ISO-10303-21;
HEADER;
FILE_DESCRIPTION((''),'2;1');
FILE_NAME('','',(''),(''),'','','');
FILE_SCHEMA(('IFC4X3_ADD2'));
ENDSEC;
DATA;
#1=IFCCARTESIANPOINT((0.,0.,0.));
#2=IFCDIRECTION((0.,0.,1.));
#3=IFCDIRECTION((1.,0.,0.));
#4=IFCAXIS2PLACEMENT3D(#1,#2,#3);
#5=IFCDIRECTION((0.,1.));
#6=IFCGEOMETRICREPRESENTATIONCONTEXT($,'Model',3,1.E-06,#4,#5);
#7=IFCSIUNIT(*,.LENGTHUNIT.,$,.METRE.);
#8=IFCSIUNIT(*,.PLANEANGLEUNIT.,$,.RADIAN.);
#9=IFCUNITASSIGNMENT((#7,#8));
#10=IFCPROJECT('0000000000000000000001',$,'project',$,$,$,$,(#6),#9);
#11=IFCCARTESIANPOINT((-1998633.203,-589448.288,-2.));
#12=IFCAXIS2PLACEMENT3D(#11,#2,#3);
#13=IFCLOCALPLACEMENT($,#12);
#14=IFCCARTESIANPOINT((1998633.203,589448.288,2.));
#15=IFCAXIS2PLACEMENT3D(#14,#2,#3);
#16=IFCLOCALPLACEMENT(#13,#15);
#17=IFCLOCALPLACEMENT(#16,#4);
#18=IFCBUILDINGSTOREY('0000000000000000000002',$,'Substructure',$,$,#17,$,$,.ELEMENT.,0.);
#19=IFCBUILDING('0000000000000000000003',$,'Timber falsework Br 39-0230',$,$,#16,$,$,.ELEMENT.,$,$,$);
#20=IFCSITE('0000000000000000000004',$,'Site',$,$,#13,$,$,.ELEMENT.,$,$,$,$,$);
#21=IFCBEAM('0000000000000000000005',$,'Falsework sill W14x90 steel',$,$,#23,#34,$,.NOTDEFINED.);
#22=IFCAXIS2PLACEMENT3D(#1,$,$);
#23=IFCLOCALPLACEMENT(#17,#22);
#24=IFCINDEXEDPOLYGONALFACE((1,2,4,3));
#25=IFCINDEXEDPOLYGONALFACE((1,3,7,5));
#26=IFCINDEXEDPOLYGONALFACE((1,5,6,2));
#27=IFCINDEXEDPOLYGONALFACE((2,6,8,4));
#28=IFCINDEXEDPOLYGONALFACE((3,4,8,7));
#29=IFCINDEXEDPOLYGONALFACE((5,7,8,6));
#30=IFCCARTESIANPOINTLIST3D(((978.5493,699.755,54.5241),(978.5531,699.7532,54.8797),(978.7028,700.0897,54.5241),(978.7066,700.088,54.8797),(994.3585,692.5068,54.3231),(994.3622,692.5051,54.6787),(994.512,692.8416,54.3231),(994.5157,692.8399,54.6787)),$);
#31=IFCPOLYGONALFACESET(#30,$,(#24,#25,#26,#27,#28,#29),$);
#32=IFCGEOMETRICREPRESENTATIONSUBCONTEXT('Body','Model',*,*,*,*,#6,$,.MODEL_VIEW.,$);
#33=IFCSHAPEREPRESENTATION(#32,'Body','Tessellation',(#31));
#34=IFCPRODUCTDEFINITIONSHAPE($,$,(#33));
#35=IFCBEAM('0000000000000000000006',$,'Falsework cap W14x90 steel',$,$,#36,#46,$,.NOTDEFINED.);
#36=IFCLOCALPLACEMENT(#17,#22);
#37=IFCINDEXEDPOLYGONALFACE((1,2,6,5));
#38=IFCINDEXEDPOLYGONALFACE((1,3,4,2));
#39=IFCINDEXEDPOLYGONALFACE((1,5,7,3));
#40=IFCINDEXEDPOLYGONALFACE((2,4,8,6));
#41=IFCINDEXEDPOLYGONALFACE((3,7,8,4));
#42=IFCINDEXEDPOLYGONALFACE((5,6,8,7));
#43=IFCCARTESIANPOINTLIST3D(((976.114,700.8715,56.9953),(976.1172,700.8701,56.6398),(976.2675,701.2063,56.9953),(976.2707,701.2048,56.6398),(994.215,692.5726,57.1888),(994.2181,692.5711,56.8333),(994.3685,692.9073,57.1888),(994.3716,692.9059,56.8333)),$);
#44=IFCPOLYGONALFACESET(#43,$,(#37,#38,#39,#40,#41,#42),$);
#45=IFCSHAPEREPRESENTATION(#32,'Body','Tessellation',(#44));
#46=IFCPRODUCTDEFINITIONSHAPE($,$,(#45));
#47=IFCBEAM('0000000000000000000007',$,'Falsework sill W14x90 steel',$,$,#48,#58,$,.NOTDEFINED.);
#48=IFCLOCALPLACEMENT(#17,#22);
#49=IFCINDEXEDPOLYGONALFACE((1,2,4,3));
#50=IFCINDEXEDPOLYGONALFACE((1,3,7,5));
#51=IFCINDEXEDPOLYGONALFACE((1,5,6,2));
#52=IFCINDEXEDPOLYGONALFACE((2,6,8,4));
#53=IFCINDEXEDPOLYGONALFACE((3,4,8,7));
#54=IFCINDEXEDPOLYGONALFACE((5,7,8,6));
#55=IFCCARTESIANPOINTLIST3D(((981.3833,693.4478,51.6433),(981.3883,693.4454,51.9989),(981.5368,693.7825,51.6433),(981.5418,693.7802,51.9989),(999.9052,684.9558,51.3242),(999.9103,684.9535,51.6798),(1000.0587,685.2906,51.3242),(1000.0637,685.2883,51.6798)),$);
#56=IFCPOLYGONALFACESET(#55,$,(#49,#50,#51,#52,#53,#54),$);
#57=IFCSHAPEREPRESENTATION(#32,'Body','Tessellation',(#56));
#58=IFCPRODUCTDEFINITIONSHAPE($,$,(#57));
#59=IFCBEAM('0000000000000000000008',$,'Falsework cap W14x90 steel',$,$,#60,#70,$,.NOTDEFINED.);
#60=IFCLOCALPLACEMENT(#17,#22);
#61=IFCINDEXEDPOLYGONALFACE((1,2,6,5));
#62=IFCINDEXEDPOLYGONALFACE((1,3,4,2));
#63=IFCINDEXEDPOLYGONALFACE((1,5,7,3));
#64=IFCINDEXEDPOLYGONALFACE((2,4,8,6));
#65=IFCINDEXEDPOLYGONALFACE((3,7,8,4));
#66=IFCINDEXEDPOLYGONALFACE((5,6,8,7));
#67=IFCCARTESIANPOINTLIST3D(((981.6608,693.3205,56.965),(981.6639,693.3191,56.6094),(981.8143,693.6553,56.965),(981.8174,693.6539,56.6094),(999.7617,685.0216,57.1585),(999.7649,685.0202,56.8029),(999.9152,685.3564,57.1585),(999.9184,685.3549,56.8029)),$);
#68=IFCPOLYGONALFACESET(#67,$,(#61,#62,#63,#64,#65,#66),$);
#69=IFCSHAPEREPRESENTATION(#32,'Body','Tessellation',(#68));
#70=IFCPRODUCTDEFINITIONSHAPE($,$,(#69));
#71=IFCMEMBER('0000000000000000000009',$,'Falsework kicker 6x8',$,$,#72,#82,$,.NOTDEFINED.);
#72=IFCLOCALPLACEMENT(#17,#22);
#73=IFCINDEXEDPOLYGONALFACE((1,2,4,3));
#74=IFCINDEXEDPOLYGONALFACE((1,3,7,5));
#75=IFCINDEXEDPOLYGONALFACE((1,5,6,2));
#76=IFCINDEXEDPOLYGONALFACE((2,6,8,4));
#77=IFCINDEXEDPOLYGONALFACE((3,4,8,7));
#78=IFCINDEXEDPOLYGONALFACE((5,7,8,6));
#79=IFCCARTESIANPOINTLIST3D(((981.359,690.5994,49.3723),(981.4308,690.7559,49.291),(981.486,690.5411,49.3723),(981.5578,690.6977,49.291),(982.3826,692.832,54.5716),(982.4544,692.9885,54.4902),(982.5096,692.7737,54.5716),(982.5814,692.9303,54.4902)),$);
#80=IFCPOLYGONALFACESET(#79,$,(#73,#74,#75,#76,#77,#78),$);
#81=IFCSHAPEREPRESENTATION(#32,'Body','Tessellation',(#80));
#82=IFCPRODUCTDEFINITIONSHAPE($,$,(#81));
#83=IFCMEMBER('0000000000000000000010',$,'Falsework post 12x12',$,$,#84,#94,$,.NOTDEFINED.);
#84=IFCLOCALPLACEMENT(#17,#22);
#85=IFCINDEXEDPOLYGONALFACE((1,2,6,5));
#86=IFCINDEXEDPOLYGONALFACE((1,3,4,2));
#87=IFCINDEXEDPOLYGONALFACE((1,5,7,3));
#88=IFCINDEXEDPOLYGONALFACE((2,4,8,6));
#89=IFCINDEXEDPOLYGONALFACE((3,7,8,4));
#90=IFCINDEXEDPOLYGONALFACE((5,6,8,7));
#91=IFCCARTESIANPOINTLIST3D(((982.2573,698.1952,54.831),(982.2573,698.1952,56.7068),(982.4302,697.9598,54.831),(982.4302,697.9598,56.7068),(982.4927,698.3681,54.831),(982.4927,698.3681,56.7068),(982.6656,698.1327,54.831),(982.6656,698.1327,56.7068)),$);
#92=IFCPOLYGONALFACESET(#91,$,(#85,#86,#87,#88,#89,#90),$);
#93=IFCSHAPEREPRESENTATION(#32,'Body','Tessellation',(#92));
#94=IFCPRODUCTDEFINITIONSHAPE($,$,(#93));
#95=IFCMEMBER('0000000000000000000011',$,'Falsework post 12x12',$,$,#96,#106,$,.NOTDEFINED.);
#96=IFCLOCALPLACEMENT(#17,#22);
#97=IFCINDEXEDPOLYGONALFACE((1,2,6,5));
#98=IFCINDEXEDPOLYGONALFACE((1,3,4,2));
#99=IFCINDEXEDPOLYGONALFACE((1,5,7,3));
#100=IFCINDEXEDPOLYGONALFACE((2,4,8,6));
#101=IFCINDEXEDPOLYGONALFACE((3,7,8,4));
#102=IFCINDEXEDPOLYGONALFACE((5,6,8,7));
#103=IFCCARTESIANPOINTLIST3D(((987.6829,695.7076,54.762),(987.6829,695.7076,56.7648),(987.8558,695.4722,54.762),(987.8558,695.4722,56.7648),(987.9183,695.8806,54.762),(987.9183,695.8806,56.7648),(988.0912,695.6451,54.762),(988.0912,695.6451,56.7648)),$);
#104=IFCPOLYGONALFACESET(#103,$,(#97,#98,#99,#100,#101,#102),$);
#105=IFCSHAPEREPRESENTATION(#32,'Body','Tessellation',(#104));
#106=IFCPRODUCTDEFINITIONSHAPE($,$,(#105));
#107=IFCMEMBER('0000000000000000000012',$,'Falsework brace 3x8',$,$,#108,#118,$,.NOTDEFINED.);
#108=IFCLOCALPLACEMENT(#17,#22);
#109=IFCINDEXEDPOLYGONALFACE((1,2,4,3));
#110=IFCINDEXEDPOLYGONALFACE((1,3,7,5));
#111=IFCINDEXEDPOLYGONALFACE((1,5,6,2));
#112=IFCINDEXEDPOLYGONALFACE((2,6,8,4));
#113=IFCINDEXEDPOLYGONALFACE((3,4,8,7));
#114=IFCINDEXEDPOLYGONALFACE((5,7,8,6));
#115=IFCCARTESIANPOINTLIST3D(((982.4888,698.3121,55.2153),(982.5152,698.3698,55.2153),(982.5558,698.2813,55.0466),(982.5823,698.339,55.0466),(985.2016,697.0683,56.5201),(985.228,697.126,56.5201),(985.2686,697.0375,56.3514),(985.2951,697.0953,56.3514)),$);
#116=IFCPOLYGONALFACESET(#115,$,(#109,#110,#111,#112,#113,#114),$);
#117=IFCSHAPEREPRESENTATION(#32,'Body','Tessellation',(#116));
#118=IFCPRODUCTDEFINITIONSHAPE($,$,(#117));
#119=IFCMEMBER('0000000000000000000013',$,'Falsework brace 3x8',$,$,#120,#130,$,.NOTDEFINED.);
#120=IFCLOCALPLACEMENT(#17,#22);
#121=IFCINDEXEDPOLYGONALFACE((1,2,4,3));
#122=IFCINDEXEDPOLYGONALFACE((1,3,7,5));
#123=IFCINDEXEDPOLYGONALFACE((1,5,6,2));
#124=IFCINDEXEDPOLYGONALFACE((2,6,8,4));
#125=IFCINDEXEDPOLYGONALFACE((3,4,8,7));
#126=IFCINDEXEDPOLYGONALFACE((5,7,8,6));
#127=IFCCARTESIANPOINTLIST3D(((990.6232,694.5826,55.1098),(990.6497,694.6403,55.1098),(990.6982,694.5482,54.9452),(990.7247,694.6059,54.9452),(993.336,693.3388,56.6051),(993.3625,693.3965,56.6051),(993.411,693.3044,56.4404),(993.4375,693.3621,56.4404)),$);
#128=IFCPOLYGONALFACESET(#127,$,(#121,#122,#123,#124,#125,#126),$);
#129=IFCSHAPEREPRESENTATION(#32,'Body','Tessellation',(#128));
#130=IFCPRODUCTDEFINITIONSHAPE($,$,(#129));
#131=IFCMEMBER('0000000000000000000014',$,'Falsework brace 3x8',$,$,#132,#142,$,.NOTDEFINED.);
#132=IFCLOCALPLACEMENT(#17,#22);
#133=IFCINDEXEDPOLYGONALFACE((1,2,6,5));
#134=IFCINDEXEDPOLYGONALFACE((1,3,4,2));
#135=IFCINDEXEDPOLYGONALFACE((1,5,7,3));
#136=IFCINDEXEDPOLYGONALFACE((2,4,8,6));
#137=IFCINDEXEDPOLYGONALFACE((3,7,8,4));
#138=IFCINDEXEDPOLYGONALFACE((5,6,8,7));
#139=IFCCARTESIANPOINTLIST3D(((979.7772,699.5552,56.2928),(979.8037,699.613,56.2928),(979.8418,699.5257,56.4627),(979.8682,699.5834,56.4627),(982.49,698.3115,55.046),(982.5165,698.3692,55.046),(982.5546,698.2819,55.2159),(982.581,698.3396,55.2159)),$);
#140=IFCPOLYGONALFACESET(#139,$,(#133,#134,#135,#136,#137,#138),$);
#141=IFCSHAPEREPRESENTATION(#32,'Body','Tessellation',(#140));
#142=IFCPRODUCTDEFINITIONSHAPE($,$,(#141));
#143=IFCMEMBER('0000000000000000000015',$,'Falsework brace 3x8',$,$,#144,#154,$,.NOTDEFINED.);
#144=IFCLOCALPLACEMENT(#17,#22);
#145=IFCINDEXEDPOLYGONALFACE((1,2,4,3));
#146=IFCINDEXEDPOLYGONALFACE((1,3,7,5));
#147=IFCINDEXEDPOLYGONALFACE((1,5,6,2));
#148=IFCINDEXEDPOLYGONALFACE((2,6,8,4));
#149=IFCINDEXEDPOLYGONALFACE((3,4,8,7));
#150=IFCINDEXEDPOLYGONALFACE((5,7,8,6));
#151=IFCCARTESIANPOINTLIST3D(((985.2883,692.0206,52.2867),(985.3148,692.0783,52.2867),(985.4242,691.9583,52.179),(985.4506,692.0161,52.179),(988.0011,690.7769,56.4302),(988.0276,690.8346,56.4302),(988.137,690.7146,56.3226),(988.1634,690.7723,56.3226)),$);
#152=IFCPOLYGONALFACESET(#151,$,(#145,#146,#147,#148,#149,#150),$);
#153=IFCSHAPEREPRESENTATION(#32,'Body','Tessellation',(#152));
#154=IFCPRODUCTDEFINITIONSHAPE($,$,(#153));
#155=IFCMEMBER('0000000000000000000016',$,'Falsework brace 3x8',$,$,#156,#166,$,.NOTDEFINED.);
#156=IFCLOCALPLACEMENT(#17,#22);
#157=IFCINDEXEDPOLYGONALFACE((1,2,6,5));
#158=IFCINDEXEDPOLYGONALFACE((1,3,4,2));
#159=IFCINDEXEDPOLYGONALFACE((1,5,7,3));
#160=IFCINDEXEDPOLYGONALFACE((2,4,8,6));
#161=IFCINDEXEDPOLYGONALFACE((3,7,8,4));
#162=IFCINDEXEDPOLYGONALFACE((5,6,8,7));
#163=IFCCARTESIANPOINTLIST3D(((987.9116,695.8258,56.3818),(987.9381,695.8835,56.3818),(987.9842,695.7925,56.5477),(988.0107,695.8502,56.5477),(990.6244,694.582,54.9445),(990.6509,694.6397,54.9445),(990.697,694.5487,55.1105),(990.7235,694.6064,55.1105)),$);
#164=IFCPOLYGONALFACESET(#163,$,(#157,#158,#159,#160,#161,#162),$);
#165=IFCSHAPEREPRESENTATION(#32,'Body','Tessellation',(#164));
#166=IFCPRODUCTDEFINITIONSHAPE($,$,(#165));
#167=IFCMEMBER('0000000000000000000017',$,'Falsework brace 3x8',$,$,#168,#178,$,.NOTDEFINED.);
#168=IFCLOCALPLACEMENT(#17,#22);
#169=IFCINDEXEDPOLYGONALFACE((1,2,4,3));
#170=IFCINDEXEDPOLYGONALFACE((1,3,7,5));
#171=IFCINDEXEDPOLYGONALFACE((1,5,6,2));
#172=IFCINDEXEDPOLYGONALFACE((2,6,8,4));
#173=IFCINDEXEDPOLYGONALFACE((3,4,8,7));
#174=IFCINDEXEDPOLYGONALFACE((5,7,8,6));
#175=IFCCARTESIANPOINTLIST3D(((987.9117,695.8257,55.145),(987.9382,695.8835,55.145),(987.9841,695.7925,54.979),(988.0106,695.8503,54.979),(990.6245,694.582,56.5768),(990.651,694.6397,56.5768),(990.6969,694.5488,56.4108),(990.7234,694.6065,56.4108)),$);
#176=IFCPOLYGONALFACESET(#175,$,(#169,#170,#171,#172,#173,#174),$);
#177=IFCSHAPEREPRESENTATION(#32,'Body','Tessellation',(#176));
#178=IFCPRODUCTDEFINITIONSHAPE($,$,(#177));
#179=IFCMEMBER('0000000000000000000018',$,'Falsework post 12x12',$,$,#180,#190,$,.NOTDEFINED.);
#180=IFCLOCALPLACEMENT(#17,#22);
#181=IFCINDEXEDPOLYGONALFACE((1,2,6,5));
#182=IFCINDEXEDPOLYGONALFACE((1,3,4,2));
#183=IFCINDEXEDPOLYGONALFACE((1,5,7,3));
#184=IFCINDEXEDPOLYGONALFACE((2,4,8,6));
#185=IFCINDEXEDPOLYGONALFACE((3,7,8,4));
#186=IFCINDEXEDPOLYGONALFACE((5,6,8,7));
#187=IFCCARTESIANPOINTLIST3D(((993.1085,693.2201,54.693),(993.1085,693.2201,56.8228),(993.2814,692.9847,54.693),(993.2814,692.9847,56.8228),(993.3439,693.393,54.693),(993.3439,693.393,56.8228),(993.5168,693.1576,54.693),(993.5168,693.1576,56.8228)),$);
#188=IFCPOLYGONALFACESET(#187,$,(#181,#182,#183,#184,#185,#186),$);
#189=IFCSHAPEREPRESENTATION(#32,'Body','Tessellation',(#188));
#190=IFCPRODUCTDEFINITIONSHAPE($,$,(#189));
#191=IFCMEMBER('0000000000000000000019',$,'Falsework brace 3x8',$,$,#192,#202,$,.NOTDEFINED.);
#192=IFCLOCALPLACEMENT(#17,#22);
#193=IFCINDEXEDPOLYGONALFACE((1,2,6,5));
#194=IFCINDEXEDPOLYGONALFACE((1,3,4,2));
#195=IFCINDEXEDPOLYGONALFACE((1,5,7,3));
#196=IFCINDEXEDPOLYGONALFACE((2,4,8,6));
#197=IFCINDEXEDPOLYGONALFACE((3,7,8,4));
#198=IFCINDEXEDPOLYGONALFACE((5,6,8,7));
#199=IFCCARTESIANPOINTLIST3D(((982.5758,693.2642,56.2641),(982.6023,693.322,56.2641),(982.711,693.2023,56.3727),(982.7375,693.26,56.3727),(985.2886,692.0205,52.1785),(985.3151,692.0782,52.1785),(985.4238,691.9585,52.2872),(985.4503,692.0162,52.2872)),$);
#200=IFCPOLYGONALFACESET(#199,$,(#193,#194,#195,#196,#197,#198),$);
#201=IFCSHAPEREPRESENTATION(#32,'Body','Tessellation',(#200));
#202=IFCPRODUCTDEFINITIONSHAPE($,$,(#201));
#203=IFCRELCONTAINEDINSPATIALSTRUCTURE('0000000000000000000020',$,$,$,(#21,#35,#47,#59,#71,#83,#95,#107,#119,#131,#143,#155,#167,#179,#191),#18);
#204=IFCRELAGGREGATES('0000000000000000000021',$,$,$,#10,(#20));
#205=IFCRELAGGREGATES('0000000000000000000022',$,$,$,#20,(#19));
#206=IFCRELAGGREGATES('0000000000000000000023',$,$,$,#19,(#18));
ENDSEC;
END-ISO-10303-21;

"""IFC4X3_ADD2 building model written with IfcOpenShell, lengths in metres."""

from ifc_helpers import new_model, si_unit, direction, frame, frame_2d, origin, origin_with_axes, origin_2d, place, context, subcontext, project, spatial, rectangle, extrude, element, save


model = new_model("IFC4X3_ADD2")

# Units and contexts
model_context = context("Model", 3, precision=1e-06, world=origin_with_axes(), true_north=direction((0.0, 1.0)))
body_context = subcontext(model_context, "Body", "Model", "MODEL_VIEW")
ifc_project = project(units=[si_unit("LENGTHUNIT", "METRE"), si_unit("PLANEANGLEUNIT", "RADIAN")], contexts=[model_context])

# Site, building, storey
site_placement = place(None, frame((-1998633.203, -589448.288, -2.0), z_axis=(0.0, 0.0, 1.0), x_axis=(1.0, 0.0, 0.0)))
site = spatial("IfcSite", under=ifc_project, at=site_placement, Name="Site", CompositionType="ELEMENT")
building_placement = place(site_placement, frame((1998633.203, 589448.288, 2.0), z_axis=(0.0, 0.0, 1.0), x_axis=(1.0, 0.0, 0.0)))
building = spatial("IfcBuilding", under=site, at=building_placement, Name="Timber falsework Br 39-0230", CompositionType="ELEMENT")
storey_placement = place(building_placement, origin_with_axes())
storey = spatial("IfcBuildingStorey", under=building, at=storey_placement, Name="Substructure", CompositionType="ELEMENT", Elevation=0.0)

# Beams
beam_1_placement = place(storey_placement, frame((978.6261, 699.9224, 54.5241), z_axis=(0.908953, -0.416737, -0.011557), x_axis=(0.416765, 0.909014, 0.0)))
element("IfcBeam", 1, at=beam_1_placement, inside=storey, Name="Falsework sill W14x90 steel", PredefinedType="NOTDEFINED", context=body_context, shape_type="SweptSolid", body=[
    extrude(rectangle(XDim=0.3683, YDim=0.3556, at=frame_2d((0.0, 0.1778))), origin(), (0.0, 0.0, 1.0), 17.3927),
])
beam_2_placement = place(storey_placement, frame((976.1939, 701.0375, 56.6398), z_axis=(0.908971, -0.416746, 0.009717), x_axis=(0.416765, 0.909014, 0.0)))
element("IfcBeam", 2, at=beam_2_placement, inside=storey, Name="Falsework cap W14x90 steel", PredefinedType="NOTDEFINED", context=body_context, shape_type="SweptSolid", body=[
    extrude(rectangle(XDim=0.3683, YDim=0.3556, at=frame_2d((0.0, 0.1778))), origin(), (0.0, 0.0, 1.0), 19.9137),
])
beam_3_placement = place(storey_placement, frame((981.46, 693.6152, 51.6433), z_axis=(0.908903, -0.416714, -0.015657), x_axis=(0.416765, 0.909014, 0.0)))
element("IfcBeam", 3, at=beam_3_placement, inside=storey, Name="Falsework sill W14x90 steel", PredefinedType="NOTDEFINED", context=body_context, shape_type="SweptSolid", body=[
    extrude(rectangle(XDim=0.3683, YDim=0.3556, at=frame_2d((0.0, 0.1778))), origin(), (0.0, 0.0, 1.0), 20.3783),
])
beam_4_placement = place(storey_placement, frame((981.7407, 693.4865, 56.6094), z_axis=(0.908971, -0.416746, 0.009717), x_axis=(0.416765, 0.909014, 0.0)))
element("IfcBeam", 4, at=beam_4_placement, inside=storey, Name="Falsework cap W14x90 steel", PredefinedType="NOTDEFINED", context=body_context, shape_type="SweptSolid", body=[
    extrude(rectangle(XDim=0.3683, YDim=0.3556, at=frame_2d((0.0, 0.1778))), origin(), (0.0, 0.0, 1.0), 19.9137),
])

# Members
member_1_placement = place(storey_placement, frame((982.482, 692.8811, 54.5309), z_axis=(-0.178013, -0.388267, -0.90419), x_axis=(0.909014, -0.416765, 0.0)))
element("IfcMember", 5, at=member_1_placement, inside=storey, Name="Falsework kicker 6x8", PredefinedType="NOTDEFINED", context=body_context, shape_type="SweptSolid", body=[
    extrude(rectangle(XDim=0.1397, YDim=0.1905, at=origin_2d()), origin(), (0.0, 0.0, 1.0), 5.7502),
])
member_2_placement = place(storey_placement, frame((982.4614, 698.1639, 54.831), z_axis=(0.0, 0.0, 1.0), x_axis=(-0.805928, -0.592013, 0.0)))
element("IfcMember", 6, at=member_2_placement, inside=storey, Name="Falsework post 12x12", PredefinedType="NOTDEFINED", context=body_context, shape_type="SweptSolid", body=[
    extrude(rectangle(XDim=0.2921, YDim=0.2921, at=origin_2d()), origin(), (0.0, 0.0, 1.0), 1.8758),
])
member_3_placement = place(storey_placement, frame((987.8871, 695.6764, 54.762), z_axis=(0.0, 0.0, 1.0), x_axis=(-0.805928, -0.592013, 0.0)))
element("IfcMember", 7, at=member_3_placement, inside=storey, Name="Falsework post 12x12", PredefinedType="NOTDEFINED", context=body_context, shape_type="SweptSolid", body=[
    extrude(rectangle(XDim=0.2921, YDim=0.2921, at=origin_2d()), origin(), (0.0, 0.0, 1.0), 2.0028),
])
member_4_placement = place(storey_placement, frame((982.5355, 698.3255, 55.131), z_axis=(0.832887, -0.381862, 0.400599), x_axis=(0.416765, 0.909014, 0.0)))
element("IfcMember", 8, at=member_4_placement, inside=storey, Name="Falsework brace 3x8", PredefinedType="NOTDEFINED", context=body_context, shape_type="SweptSolid", body=[
    extrude(rectangle(XDim=0.0635, YDim=0.1841, at=origin_2d()), origin(), (0.0, 0.0, 1.0), 3.2571),
])
member_5_placement = place(storey_placement, frame((990.674, 694.5942, 55.0275), z_axis=(0.812709, -0.372611, 0.447957), x_axis=(0.416765, 0.909014, 0.0)))
element("IfcMember", 9, at=member_5_placement, inside=storey, Name="Falsework brace 3x8", PredefinedType="NOTDEFINED", context=body_context, shape_type="SweptSolid", body=[
    extrude(rectangle(XDim=0.0635, YDim=0.1841, at=origin_2d()), origin(), (0.0, 0.0, 1.0), 3.338),
])
member_6_placement = place(storey_placement, frame((979.8227, 699.5693, 56.3778), z_axis=(0.838758, -0.384554, -0.385491), x_axis=(0.416765, 0.909014, 0.0)))
element("IfcMember", 10, at=member_6_placement, inside=storey, Name="Falsework brace 3x8", PredefinedType="NOTDEFINED", context=body_context, shape_type="SweptSolid", body=[
    extrude(rectangle(XDim=0.0635, YDim=0.1841, at=origin_2d()), origin(), (0.0, 0.0, 1.0), 3.2343),
])
member_7_placement = place(storey_placement, frame((985.3695, 692.0183, 52.2329), z_axis=(0.531259, -0.243572, 0.811441), x_axis=(0.416765, 0.909014, 0.0)))
element("IfcMember", 11, at=member_7_placement, inside=storey, Name="Falsework brace 3x8", PredefinedType="NOTDEFINED", context=body_context, shape_type="SweptSolid", body=[
    extrude(rectangle(XDim=0.0635, YDim=0.1841, at=origin_2d()), origin(), (0.0, 0.0, 1.0), 5.1064),
])
member_8_placement = place(storey_placement, frame((987.9612, 695.838, 56.4648), z_axis=(0.818984, -0.375488, -0.433905), x_axis=(0.416765, 0.909014, 0.0)))
element("IfcMember", 12, at=member_8_placement, inside=storey, Name="Falsework brace 3x8", PredefinedType="NOTDEFINED", context=body_context, shape_type="SweptSolid", body=[
    extrude(rectangle(XDim=0.0635, YDim=0.1841, at=origin_2d()), origin(), (0.0, 0.0, 1.0), 3.3124),
])
member_9_placement = place(storey_placement, frame((987.9612, 695.838, 55.062), z_axis=(0.819573, -0.375758, 0.432558), x_axis=(0.416765, 0.909014, 0.0)))
element("IfcMember", 13, at=member_9_placement, inside=storey, Name="Falsework brace 3x8", PredefinedType="NOTDEFINED", context=body_context, shape_type="SweptSolid", body=[
    extrude(rectangle(XDim=0.0635, YDim=0.1841, at=origin_2d()), origin(), (0.0, 0.0, 1.0), 3.31),
])
member_10_placement = place(storey_placement, frame((993.3127, 693.1888, 54.693), z_axis=(0.0, 0.0, 1.0), x_axis=(-0.805928, -0.592013, 0.0)))
element("IfcMember", 14, at=member_10_placement, inside=storey, Name="Falsework post 12x12", PredefinedType="NOTDEFINED", context=body_context, shape_type="SweptSolid", body=[
    extrude(rectangle(XDim=0.2921, YDim=0.2921, at=origin_2d()), origin(), (0.0, 0.0, 1.0), 2.1298),
])
member_11_placement = place(storey_placement, frame((982.6567, 693.2621, 56.3184), z_axis=(0.536189, -0.245832, -0.807508), x_axis=(0.416765, 0.909014, 0.0)))
element("IfcMember", 15, at=member_11_placement, inside=storey, Name="Falsework brace 3x8", PredefinedType="NOTDEFINED", context=body_context, shape_type="SweptSolid", body=[
    extrude(rectangle(XDim=0.0635, YDim=0.1841, at=origin_2d()), origin(), (0.0, 0.0, 1.0), 5.0594),
])

save(model, "model.ifc")
